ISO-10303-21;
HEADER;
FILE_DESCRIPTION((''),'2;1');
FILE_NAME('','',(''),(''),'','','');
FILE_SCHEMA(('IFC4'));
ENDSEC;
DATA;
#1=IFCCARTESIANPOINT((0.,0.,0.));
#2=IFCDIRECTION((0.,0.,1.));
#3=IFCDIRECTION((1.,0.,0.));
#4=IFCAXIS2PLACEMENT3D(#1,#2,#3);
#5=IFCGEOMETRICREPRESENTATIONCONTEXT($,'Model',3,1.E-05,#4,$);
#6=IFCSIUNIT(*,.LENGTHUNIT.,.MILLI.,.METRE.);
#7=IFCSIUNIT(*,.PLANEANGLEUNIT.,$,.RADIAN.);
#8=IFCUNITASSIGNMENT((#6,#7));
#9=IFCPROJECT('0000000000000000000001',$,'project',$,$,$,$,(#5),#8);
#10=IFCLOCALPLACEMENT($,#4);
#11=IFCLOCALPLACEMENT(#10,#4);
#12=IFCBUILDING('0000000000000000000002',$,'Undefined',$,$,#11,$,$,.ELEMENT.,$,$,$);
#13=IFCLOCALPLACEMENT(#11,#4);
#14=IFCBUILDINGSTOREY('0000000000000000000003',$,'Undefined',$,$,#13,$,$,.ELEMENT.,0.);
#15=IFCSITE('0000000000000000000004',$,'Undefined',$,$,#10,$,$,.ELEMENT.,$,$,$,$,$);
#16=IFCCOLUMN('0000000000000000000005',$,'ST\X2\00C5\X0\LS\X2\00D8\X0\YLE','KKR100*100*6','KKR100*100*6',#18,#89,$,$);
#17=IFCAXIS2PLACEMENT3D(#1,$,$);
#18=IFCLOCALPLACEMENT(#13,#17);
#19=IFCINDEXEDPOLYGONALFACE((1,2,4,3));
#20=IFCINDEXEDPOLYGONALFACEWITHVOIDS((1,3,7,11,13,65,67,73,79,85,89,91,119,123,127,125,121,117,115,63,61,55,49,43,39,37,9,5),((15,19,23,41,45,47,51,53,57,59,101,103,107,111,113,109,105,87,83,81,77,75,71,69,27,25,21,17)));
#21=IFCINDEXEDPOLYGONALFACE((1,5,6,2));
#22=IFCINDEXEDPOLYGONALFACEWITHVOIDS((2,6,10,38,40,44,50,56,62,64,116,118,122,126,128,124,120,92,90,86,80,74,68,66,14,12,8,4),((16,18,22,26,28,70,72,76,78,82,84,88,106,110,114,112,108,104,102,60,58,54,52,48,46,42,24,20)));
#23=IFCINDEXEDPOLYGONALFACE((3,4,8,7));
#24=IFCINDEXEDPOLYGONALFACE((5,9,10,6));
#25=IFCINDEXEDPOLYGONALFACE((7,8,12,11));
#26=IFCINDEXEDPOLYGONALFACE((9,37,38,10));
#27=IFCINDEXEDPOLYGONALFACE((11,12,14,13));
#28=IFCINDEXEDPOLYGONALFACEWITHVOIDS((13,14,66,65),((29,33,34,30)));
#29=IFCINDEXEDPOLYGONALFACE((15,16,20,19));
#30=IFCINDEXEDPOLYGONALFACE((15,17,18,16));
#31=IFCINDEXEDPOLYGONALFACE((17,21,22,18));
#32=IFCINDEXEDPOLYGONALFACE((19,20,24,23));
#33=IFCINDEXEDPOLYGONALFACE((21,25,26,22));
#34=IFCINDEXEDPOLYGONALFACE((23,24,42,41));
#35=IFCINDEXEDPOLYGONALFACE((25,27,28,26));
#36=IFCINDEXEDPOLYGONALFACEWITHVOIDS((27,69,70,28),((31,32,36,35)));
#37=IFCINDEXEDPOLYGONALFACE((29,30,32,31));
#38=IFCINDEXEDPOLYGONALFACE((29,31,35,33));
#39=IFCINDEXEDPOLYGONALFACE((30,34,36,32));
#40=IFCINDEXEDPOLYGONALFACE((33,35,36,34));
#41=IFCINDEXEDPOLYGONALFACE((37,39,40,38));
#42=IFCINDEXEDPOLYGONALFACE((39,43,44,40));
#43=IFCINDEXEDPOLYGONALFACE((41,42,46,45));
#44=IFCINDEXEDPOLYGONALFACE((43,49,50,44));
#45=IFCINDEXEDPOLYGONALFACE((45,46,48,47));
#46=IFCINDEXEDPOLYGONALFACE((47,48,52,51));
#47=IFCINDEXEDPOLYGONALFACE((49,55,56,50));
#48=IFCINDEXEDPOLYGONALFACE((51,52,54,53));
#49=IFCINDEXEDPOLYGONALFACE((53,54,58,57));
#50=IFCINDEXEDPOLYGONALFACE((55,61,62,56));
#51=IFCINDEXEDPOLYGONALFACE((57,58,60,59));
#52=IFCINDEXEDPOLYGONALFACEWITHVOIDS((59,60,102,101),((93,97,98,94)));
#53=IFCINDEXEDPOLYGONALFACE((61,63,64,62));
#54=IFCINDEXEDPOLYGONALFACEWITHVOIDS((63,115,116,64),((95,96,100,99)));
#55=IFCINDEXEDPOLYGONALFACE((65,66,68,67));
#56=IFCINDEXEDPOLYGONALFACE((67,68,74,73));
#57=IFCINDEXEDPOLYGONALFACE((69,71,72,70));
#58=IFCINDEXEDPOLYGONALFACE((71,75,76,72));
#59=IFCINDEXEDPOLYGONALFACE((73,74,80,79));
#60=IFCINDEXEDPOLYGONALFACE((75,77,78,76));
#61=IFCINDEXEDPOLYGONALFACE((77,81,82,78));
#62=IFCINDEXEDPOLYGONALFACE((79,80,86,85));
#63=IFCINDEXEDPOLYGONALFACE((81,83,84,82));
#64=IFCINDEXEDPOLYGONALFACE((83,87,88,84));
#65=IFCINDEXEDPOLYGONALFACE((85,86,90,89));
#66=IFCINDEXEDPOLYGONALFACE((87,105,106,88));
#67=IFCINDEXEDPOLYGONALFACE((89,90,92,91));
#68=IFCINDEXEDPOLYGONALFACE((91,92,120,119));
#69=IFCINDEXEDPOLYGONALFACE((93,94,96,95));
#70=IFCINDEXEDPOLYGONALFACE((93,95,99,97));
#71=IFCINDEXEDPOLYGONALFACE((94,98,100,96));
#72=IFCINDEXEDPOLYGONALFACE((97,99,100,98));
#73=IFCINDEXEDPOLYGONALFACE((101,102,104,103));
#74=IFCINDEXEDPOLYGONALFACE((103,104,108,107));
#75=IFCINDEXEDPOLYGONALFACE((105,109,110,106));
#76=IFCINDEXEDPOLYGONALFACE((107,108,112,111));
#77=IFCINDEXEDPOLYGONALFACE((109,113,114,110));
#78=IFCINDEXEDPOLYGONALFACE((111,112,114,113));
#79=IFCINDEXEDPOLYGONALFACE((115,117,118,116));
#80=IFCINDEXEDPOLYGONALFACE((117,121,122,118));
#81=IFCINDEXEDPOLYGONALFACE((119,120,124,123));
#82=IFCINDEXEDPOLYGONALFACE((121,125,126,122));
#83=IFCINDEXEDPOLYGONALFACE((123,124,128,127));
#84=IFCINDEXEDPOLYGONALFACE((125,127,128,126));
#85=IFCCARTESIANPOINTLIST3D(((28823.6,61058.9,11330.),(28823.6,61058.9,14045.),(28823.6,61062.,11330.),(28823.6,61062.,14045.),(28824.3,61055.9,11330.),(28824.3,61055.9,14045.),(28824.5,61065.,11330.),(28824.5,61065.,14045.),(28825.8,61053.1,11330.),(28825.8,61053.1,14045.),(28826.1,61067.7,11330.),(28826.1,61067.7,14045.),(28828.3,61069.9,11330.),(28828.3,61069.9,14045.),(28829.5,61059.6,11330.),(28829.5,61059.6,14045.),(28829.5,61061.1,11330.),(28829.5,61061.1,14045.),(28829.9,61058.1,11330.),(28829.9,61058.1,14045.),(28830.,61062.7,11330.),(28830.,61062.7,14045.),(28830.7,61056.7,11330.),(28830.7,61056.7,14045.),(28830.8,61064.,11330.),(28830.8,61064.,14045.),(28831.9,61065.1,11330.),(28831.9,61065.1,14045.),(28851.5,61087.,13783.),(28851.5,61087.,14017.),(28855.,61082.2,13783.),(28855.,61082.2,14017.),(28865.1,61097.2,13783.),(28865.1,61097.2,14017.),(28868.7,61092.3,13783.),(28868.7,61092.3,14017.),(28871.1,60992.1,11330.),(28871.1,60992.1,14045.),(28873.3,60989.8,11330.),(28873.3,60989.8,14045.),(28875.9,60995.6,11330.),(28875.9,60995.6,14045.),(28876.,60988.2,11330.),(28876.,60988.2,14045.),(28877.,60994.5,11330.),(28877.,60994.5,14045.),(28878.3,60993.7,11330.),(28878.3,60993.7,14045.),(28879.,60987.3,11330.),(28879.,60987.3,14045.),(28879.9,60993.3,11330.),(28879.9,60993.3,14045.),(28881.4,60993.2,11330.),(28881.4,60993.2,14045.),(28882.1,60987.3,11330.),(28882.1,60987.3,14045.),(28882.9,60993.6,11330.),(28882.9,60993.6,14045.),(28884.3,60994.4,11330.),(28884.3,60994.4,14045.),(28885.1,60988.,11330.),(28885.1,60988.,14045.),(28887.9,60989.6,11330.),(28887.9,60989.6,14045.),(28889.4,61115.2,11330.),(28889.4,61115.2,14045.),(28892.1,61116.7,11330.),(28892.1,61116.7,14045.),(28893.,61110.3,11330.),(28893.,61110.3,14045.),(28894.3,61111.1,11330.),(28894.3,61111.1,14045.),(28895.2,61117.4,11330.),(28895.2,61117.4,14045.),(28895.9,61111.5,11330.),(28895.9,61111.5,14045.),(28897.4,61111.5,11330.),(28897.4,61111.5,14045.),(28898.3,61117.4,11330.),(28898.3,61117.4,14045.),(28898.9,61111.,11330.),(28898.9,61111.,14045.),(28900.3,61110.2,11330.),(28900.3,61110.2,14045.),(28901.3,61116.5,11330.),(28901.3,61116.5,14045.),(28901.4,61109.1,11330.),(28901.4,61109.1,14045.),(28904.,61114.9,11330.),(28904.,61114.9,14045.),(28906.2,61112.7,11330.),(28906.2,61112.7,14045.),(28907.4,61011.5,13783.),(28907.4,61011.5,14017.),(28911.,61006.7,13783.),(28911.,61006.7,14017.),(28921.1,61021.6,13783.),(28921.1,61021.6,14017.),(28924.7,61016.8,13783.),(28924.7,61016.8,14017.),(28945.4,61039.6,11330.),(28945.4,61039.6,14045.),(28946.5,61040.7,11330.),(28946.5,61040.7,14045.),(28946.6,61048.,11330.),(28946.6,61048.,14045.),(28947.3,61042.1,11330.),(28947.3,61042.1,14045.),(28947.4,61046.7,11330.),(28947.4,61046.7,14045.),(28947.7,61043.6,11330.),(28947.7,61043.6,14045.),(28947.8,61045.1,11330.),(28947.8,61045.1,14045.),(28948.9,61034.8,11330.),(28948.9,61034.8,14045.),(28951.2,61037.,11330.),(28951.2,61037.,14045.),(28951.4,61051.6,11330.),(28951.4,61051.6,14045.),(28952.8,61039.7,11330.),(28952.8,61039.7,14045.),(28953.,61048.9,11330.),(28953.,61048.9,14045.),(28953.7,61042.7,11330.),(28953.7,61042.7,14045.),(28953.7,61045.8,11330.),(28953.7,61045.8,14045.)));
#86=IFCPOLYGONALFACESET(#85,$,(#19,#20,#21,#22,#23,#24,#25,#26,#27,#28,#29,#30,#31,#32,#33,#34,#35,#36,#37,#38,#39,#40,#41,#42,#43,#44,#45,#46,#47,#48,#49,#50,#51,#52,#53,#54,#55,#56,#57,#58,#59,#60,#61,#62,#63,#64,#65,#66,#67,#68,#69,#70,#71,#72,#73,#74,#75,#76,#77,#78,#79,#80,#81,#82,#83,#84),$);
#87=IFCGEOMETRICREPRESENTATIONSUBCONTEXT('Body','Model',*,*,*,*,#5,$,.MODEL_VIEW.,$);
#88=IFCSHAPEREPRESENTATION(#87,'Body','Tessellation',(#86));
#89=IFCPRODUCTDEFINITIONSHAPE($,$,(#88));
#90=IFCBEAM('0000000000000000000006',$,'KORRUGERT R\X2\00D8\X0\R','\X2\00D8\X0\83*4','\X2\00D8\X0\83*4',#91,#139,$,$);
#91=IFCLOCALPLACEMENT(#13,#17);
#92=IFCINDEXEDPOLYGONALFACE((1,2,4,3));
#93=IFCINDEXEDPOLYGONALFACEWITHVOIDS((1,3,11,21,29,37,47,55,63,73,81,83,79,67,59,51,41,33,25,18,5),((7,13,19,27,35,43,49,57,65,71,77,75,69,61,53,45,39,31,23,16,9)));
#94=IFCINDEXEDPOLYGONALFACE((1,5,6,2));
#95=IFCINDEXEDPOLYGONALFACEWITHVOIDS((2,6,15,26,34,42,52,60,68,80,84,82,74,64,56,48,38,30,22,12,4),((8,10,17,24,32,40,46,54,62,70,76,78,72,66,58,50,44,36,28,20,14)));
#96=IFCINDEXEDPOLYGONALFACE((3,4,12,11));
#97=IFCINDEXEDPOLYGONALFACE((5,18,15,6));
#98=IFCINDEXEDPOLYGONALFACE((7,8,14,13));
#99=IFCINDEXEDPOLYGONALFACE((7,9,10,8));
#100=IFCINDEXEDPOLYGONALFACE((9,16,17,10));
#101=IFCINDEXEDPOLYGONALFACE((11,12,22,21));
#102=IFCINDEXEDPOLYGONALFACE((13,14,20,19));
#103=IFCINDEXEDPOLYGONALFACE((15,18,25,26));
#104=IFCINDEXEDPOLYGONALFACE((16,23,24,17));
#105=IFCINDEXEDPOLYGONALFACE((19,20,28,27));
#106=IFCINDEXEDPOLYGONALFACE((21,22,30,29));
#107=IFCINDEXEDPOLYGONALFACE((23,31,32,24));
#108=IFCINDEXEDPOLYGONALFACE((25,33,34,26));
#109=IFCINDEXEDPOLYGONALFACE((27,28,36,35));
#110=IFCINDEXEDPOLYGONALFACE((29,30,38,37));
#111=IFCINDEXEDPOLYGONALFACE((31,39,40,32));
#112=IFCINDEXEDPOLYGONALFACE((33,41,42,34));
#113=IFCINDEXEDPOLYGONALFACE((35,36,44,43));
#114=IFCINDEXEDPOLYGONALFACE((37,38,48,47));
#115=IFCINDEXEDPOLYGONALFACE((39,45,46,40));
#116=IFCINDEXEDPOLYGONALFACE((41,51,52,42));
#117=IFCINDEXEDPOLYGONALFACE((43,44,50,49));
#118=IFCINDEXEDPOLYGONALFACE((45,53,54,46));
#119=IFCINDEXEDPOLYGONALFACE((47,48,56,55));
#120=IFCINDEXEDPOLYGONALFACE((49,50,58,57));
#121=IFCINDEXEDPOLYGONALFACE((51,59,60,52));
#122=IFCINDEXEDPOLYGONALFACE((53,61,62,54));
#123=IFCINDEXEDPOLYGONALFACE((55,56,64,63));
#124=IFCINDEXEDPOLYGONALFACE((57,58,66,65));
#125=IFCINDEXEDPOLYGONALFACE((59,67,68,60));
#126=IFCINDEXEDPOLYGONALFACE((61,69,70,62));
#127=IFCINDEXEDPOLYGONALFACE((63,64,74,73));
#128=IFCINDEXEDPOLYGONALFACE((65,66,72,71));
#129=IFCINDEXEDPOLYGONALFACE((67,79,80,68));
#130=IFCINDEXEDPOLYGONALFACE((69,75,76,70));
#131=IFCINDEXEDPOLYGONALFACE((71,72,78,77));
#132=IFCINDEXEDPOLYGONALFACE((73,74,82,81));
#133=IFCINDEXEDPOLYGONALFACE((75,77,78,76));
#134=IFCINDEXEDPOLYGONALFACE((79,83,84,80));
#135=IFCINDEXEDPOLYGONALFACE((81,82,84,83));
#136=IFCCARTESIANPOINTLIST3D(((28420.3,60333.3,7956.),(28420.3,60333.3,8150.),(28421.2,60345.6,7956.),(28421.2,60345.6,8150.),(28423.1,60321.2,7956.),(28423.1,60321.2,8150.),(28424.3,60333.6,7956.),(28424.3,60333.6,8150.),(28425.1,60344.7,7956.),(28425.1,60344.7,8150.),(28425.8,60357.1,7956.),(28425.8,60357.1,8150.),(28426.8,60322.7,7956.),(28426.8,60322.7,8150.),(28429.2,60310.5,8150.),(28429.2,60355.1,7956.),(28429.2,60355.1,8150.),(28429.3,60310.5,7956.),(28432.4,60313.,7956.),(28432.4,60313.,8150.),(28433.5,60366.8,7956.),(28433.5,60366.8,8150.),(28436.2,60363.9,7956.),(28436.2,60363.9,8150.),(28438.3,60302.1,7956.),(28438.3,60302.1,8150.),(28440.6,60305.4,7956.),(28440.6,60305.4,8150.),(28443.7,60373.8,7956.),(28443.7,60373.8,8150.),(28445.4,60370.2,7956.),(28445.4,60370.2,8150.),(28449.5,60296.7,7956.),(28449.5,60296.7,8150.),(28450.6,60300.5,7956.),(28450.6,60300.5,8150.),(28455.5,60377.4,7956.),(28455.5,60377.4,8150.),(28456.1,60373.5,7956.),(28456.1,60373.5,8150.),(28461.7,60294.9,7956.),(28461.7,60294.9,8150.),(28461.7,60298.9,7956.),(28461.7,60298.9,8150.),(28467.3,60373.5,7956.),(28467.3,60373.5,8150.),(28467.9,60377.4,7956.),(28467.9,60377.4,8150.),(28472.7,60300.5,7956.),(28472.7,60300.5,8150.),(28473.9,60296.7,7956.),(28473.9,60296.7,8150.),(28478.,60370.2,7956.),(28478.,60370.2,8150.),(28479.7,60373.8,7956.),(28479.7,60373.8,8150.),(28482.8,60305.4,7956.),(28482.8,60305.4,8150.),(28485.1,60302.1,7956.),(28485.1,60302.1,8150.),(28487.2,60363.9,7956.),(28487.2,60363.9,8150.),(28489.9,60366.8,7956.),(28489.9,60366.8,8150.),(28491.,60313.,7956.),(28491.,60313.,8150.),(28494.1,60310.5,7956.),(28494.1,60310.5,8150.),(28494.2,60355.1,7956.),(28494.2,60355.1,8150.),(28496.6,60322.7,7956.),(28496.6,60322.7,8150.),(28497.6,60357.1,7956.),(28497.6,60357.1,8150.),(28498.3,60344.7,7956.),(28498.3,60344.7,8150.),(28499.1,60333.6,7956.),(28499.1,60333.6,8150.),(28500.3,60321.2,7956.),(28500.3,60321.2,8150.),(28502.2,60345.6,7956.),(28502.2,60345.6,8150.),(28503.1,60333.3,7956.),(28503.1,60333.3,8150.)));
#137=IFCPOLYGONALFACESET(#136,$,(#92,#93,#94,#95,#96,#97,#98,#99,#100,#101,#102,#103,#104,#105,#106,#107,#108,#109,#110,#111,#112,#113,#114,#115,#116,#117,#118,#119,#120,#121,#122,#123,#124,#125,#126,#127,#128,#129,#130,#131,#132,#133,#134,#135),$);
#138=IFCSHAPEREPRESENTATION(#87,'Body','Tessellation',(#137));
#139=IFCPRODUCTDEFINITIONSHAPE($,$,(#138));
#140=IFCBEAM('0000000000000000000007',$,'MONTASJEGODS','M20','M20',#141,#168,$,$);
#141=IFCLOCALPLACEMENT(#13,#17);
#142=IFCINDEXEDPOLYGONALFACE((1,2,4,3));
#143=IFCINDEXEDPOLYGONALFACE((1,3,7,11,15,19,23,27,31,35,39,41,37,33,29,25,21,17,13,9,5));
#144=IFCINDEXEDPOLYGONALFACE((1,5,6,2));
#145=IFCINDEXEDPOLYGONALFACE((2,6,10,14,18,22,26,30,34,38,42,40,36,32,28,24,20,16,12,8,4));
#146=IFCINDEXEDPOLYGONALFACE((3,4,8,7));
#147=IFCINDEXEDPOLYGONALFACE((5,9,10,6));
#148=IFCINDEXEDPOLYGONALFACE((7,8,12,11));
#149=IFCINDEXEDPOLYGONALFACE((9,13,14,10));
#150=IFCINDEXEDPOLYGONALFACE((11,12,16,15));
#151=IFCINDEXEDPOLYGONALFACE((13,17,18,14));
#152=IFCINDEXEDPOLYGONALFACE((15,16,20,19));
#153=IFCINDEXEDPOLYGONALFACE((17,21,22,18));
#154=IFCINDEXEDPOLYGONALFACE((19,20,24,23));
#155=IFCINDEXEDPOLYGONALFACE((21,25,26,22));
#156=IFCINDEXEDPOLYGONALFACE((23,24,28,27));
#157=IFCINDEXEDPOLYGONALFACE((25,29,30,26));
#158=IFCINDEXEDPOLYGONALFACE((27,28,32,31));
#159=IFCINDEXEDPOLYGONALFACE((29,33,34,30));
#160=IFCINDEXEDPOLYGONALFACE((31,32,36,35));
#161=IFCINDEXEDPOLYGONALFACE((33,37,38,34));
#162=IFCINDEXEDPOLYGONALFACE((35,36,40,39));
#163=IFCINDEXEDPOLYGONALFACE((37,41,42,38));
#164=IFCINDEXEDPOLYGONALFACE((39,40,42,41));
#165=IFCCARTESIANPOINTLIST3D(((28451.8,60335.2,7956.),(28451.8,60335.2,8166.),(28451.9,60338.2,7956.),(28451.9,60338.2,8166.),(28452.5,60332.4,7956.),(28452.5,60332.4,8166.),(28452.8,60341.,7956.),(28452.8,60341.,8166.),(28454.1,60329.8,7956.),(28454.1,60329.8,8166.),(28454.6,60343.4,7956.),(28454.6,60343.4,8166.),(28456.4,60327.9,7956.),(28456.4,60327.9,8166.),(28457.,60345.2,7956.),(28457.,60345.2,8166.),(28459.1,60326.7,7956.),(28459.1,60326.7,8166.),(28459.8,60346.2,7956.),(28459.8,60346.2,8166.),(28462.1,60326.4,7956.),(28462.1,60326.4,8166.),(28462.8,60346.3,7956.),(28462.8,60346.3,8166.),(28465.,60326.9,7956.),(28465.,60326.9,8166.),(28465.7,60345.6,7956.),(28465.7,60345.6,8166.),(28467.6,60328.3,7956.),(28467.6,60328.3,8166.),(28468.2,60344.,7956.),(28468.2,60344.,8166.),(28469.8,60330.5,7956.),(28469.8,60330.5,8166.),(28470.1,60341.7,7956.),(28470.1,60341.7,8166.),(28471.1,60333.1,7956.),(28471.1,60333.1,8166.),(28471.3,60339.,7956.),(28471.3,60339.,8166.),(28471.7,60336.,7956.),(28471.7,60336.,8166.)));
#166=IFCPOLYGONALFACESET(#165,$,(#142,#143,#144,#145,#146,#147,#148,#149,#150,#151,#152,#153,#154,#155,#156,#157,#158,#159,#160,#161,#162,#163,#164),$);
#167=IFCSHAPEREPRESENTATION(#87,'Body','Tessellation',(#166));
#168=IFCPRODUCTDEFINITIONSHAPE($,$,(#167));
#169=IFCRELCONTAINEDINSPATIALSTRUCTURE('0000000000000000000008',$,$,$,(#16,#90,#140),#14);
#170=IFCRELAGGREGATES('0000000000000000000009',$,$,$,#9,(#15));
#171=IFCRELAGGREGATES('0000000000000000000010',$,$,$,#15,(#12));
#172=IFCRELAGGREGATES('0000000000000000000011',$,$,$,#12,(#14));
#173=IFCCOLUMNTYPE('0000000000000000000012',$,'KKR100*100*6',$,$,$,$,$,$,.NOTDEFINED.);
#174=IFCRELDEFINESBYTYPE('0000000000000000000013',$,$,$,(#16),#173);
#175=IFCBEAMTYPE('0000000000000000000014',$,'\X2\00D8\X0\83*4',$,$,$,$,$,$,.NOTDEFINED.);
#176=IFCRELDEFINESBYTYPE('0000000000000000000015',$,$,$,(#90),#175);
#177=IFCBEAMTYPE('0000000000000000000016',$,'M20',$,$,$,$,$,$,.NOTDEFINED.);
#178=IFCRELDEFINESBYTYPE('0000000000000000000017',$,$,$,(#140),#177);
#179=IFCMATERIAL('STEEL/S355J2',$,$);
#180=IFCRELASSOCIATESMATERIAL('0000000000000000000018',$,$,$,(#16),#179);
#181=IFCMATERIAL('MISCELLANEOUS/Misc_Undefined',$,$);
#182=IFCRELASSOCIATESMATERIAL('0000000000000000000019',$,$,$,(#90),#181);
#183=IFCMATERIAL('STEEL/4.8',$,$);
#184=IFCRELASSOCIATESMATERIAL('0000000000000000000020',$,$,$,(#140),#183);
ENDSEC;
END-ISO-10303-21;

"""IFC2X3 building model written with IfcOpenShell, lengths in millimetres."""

from ifc_helpers import new_model, si_unit, frame, origin_with_axes, origin_2d_with_axis, place, context, subcontext, project, spatial, polyline, hollow_rectangle, circle, hollow_circle, outline, extrude, boolean, halfspace, material, type_object, element, save


model = new_model("IFC2X3")

# Units and contexts
model_context = context("Model", 3, precision=1e-05, world=origin_with_axes())
body_context = subcontext(model_context, "Body", "Model", "MODEL_VIEW")
ifc_project = project(units=[si_unit("LENGTHUNIT", "METRE", prefix="MILLI"), si_unit("PLANEANGLEUNIT", "RADIAN")], contexts=[model_context])

# Site, building, storey
site_placement = place(None, origin_with_axes())
site = spatial("IfcSite", under=ifc_project, at=site_placement, Name="Undefined", CompositionType="ELEMENT")
building_placement = place(site_placement, origin_with_axes())
building = spatial("IfcBuilding", under=site, at=building_placement, Name="Undefined", CompositionType="ELEMENT")
storey_placement = place(building_placement, origin_with_axes())
storey = spatial("IfcBuildingStorey", under=building, at=storey_placement, Name="Undefined", CompositionType="ELEMENT", Elevation=0.0)

# Column
ifc_material_1 = material(Name="STEEL/S355J2")
column_type_1 = type_object("IfcColumnType", Name="KKR100*100*6", PredefinedType="NOTDEFINED")
column_placement = place(storey_placement, frame((28888.6, 61052.4, 11330.0), z_axis=(0.0, 0.0, 1.0), x_axis=(-0.595445, 0.803396, 0.0)))
element("IfcColumn", 1, at=column_placement, inside=storey, type_object=column_type_1, material=ifc_material_1, Name="STÅLSØYLE", Description="KKR100*100*6", ObjectType="KKR100*100*6", context=body_context, shape_type="CSG", body=[
    boolean("DIFFERENCE", boolean("DIFFERENCE", boolean("DIFFERENCE", extrude(hollow_rectangle(XDim=100.0, YDim=100.0, WallThickness=6.0, InnerFilletRadius=6.0, OuterFilletRadius=12.0, at=origin_2d_with_axis()), frame((0.0, 0.0, 2715.0), z_axis=(0.0, 0.0, -1.0), x_axis=(0.0, 1.0, 0.0)), (0.0, 0.0, 1.0), 2715.0), extrude(outline(polyline([(0.0, 0.0), (17.0, 0.0), (17.0, 234.0), (0.0, 234.0), (0.0, 0.0)])), frame((34.0, 9.2, 2687.0), z_axis=(1.0, 0.000021, 0.0), x_axis=(0.000019, -1.0, 0.0)), (0.0, 0.0, 1.0), 26.0)), extrude(outline(polyline([(0.0, 0.0), (17.0, 0.0), (17.0, 234.0), (0.0, 234.0), (0.0, 0.0)])), frame((-60.0, 9.2, 2687.0), z_axis=(1.0, 0.000021, 0.0), x_axis=(0.000019, -1.0, 0.0)), (0.0, 0.0, 1.0), 26.0)), halfspace(frame((-50.0, 0.0, 2715.0), z_axis=(0.0, 0.0, -1.0), x_axis=(0.0, -1.0, 0.0)), True)),
])

# Beams
ifc_material_2 = material(Name="MISCELLANEOUS/Misc_Undefined")
beam_type_1 = type_object("IfcBeamType", Name="Ø83*4", PredefinedType="NOTDEFINED")
beam_1_placement = place(storey_placement, frame((28461.7, 60336.4, 8150.0), z_axis=(1.0, 0.0, 0.000023), x_axis=(0.000023, -0.000006, -1.0)))
element("IfcBeam", 2, at=beam_1_placement, inside=storey, type_object=beam_type_1, material=ifc_material_2, Name="KORRUGERT RØR", Description="Ø83*4", ObjectType="Ø83*4", context=body_context, shape_type="SweptSolid", body=[
    extrude(hollow_circle(Radius=41.5, WallThickness=4.0, at=origin_2d_with_axis()), frame((194.0, 0.0, 0.0), z_axis=(-1.0, 0.0, 0.0), x_axis=(0.0, -1.0, 0.0)), (0.0, 0.0, 1.0), 194.0),
])
ifc_material_3 = material(Name="STEEL/4.8")
beam_type_2 = type_object("IfcBeamType", Name="M20", PredefinedType="NOTDEFINED")
beam_2_placement = place(storey_placement, frame((28461.7, 60336.4, 8166.0), z_axis=(0.803376, 0.595472, 0.0), x_axis=(0.0, 0.0, -1.0)))
element("IfcBeam", 3, at=beam_2_placement, inside=storey, type_object=beam_type_2, material=ifc_material_3, Name="MONTASJEGODS", Description="M20", ObjectType="M20", context=body_context, shape_type="SweptSolid", body=[
    extrude(circle(Radius=10.0, at=origin_2d_with_axis()), frame((210.0, 0.0, 0.0), z_axis=(-1.0, 0.0, 0.0), x_axis=(0.0, -1.0, 0.0)), (0.0, 0.0, 1.0), 210.0),
])

save(model, "model.ifc")
